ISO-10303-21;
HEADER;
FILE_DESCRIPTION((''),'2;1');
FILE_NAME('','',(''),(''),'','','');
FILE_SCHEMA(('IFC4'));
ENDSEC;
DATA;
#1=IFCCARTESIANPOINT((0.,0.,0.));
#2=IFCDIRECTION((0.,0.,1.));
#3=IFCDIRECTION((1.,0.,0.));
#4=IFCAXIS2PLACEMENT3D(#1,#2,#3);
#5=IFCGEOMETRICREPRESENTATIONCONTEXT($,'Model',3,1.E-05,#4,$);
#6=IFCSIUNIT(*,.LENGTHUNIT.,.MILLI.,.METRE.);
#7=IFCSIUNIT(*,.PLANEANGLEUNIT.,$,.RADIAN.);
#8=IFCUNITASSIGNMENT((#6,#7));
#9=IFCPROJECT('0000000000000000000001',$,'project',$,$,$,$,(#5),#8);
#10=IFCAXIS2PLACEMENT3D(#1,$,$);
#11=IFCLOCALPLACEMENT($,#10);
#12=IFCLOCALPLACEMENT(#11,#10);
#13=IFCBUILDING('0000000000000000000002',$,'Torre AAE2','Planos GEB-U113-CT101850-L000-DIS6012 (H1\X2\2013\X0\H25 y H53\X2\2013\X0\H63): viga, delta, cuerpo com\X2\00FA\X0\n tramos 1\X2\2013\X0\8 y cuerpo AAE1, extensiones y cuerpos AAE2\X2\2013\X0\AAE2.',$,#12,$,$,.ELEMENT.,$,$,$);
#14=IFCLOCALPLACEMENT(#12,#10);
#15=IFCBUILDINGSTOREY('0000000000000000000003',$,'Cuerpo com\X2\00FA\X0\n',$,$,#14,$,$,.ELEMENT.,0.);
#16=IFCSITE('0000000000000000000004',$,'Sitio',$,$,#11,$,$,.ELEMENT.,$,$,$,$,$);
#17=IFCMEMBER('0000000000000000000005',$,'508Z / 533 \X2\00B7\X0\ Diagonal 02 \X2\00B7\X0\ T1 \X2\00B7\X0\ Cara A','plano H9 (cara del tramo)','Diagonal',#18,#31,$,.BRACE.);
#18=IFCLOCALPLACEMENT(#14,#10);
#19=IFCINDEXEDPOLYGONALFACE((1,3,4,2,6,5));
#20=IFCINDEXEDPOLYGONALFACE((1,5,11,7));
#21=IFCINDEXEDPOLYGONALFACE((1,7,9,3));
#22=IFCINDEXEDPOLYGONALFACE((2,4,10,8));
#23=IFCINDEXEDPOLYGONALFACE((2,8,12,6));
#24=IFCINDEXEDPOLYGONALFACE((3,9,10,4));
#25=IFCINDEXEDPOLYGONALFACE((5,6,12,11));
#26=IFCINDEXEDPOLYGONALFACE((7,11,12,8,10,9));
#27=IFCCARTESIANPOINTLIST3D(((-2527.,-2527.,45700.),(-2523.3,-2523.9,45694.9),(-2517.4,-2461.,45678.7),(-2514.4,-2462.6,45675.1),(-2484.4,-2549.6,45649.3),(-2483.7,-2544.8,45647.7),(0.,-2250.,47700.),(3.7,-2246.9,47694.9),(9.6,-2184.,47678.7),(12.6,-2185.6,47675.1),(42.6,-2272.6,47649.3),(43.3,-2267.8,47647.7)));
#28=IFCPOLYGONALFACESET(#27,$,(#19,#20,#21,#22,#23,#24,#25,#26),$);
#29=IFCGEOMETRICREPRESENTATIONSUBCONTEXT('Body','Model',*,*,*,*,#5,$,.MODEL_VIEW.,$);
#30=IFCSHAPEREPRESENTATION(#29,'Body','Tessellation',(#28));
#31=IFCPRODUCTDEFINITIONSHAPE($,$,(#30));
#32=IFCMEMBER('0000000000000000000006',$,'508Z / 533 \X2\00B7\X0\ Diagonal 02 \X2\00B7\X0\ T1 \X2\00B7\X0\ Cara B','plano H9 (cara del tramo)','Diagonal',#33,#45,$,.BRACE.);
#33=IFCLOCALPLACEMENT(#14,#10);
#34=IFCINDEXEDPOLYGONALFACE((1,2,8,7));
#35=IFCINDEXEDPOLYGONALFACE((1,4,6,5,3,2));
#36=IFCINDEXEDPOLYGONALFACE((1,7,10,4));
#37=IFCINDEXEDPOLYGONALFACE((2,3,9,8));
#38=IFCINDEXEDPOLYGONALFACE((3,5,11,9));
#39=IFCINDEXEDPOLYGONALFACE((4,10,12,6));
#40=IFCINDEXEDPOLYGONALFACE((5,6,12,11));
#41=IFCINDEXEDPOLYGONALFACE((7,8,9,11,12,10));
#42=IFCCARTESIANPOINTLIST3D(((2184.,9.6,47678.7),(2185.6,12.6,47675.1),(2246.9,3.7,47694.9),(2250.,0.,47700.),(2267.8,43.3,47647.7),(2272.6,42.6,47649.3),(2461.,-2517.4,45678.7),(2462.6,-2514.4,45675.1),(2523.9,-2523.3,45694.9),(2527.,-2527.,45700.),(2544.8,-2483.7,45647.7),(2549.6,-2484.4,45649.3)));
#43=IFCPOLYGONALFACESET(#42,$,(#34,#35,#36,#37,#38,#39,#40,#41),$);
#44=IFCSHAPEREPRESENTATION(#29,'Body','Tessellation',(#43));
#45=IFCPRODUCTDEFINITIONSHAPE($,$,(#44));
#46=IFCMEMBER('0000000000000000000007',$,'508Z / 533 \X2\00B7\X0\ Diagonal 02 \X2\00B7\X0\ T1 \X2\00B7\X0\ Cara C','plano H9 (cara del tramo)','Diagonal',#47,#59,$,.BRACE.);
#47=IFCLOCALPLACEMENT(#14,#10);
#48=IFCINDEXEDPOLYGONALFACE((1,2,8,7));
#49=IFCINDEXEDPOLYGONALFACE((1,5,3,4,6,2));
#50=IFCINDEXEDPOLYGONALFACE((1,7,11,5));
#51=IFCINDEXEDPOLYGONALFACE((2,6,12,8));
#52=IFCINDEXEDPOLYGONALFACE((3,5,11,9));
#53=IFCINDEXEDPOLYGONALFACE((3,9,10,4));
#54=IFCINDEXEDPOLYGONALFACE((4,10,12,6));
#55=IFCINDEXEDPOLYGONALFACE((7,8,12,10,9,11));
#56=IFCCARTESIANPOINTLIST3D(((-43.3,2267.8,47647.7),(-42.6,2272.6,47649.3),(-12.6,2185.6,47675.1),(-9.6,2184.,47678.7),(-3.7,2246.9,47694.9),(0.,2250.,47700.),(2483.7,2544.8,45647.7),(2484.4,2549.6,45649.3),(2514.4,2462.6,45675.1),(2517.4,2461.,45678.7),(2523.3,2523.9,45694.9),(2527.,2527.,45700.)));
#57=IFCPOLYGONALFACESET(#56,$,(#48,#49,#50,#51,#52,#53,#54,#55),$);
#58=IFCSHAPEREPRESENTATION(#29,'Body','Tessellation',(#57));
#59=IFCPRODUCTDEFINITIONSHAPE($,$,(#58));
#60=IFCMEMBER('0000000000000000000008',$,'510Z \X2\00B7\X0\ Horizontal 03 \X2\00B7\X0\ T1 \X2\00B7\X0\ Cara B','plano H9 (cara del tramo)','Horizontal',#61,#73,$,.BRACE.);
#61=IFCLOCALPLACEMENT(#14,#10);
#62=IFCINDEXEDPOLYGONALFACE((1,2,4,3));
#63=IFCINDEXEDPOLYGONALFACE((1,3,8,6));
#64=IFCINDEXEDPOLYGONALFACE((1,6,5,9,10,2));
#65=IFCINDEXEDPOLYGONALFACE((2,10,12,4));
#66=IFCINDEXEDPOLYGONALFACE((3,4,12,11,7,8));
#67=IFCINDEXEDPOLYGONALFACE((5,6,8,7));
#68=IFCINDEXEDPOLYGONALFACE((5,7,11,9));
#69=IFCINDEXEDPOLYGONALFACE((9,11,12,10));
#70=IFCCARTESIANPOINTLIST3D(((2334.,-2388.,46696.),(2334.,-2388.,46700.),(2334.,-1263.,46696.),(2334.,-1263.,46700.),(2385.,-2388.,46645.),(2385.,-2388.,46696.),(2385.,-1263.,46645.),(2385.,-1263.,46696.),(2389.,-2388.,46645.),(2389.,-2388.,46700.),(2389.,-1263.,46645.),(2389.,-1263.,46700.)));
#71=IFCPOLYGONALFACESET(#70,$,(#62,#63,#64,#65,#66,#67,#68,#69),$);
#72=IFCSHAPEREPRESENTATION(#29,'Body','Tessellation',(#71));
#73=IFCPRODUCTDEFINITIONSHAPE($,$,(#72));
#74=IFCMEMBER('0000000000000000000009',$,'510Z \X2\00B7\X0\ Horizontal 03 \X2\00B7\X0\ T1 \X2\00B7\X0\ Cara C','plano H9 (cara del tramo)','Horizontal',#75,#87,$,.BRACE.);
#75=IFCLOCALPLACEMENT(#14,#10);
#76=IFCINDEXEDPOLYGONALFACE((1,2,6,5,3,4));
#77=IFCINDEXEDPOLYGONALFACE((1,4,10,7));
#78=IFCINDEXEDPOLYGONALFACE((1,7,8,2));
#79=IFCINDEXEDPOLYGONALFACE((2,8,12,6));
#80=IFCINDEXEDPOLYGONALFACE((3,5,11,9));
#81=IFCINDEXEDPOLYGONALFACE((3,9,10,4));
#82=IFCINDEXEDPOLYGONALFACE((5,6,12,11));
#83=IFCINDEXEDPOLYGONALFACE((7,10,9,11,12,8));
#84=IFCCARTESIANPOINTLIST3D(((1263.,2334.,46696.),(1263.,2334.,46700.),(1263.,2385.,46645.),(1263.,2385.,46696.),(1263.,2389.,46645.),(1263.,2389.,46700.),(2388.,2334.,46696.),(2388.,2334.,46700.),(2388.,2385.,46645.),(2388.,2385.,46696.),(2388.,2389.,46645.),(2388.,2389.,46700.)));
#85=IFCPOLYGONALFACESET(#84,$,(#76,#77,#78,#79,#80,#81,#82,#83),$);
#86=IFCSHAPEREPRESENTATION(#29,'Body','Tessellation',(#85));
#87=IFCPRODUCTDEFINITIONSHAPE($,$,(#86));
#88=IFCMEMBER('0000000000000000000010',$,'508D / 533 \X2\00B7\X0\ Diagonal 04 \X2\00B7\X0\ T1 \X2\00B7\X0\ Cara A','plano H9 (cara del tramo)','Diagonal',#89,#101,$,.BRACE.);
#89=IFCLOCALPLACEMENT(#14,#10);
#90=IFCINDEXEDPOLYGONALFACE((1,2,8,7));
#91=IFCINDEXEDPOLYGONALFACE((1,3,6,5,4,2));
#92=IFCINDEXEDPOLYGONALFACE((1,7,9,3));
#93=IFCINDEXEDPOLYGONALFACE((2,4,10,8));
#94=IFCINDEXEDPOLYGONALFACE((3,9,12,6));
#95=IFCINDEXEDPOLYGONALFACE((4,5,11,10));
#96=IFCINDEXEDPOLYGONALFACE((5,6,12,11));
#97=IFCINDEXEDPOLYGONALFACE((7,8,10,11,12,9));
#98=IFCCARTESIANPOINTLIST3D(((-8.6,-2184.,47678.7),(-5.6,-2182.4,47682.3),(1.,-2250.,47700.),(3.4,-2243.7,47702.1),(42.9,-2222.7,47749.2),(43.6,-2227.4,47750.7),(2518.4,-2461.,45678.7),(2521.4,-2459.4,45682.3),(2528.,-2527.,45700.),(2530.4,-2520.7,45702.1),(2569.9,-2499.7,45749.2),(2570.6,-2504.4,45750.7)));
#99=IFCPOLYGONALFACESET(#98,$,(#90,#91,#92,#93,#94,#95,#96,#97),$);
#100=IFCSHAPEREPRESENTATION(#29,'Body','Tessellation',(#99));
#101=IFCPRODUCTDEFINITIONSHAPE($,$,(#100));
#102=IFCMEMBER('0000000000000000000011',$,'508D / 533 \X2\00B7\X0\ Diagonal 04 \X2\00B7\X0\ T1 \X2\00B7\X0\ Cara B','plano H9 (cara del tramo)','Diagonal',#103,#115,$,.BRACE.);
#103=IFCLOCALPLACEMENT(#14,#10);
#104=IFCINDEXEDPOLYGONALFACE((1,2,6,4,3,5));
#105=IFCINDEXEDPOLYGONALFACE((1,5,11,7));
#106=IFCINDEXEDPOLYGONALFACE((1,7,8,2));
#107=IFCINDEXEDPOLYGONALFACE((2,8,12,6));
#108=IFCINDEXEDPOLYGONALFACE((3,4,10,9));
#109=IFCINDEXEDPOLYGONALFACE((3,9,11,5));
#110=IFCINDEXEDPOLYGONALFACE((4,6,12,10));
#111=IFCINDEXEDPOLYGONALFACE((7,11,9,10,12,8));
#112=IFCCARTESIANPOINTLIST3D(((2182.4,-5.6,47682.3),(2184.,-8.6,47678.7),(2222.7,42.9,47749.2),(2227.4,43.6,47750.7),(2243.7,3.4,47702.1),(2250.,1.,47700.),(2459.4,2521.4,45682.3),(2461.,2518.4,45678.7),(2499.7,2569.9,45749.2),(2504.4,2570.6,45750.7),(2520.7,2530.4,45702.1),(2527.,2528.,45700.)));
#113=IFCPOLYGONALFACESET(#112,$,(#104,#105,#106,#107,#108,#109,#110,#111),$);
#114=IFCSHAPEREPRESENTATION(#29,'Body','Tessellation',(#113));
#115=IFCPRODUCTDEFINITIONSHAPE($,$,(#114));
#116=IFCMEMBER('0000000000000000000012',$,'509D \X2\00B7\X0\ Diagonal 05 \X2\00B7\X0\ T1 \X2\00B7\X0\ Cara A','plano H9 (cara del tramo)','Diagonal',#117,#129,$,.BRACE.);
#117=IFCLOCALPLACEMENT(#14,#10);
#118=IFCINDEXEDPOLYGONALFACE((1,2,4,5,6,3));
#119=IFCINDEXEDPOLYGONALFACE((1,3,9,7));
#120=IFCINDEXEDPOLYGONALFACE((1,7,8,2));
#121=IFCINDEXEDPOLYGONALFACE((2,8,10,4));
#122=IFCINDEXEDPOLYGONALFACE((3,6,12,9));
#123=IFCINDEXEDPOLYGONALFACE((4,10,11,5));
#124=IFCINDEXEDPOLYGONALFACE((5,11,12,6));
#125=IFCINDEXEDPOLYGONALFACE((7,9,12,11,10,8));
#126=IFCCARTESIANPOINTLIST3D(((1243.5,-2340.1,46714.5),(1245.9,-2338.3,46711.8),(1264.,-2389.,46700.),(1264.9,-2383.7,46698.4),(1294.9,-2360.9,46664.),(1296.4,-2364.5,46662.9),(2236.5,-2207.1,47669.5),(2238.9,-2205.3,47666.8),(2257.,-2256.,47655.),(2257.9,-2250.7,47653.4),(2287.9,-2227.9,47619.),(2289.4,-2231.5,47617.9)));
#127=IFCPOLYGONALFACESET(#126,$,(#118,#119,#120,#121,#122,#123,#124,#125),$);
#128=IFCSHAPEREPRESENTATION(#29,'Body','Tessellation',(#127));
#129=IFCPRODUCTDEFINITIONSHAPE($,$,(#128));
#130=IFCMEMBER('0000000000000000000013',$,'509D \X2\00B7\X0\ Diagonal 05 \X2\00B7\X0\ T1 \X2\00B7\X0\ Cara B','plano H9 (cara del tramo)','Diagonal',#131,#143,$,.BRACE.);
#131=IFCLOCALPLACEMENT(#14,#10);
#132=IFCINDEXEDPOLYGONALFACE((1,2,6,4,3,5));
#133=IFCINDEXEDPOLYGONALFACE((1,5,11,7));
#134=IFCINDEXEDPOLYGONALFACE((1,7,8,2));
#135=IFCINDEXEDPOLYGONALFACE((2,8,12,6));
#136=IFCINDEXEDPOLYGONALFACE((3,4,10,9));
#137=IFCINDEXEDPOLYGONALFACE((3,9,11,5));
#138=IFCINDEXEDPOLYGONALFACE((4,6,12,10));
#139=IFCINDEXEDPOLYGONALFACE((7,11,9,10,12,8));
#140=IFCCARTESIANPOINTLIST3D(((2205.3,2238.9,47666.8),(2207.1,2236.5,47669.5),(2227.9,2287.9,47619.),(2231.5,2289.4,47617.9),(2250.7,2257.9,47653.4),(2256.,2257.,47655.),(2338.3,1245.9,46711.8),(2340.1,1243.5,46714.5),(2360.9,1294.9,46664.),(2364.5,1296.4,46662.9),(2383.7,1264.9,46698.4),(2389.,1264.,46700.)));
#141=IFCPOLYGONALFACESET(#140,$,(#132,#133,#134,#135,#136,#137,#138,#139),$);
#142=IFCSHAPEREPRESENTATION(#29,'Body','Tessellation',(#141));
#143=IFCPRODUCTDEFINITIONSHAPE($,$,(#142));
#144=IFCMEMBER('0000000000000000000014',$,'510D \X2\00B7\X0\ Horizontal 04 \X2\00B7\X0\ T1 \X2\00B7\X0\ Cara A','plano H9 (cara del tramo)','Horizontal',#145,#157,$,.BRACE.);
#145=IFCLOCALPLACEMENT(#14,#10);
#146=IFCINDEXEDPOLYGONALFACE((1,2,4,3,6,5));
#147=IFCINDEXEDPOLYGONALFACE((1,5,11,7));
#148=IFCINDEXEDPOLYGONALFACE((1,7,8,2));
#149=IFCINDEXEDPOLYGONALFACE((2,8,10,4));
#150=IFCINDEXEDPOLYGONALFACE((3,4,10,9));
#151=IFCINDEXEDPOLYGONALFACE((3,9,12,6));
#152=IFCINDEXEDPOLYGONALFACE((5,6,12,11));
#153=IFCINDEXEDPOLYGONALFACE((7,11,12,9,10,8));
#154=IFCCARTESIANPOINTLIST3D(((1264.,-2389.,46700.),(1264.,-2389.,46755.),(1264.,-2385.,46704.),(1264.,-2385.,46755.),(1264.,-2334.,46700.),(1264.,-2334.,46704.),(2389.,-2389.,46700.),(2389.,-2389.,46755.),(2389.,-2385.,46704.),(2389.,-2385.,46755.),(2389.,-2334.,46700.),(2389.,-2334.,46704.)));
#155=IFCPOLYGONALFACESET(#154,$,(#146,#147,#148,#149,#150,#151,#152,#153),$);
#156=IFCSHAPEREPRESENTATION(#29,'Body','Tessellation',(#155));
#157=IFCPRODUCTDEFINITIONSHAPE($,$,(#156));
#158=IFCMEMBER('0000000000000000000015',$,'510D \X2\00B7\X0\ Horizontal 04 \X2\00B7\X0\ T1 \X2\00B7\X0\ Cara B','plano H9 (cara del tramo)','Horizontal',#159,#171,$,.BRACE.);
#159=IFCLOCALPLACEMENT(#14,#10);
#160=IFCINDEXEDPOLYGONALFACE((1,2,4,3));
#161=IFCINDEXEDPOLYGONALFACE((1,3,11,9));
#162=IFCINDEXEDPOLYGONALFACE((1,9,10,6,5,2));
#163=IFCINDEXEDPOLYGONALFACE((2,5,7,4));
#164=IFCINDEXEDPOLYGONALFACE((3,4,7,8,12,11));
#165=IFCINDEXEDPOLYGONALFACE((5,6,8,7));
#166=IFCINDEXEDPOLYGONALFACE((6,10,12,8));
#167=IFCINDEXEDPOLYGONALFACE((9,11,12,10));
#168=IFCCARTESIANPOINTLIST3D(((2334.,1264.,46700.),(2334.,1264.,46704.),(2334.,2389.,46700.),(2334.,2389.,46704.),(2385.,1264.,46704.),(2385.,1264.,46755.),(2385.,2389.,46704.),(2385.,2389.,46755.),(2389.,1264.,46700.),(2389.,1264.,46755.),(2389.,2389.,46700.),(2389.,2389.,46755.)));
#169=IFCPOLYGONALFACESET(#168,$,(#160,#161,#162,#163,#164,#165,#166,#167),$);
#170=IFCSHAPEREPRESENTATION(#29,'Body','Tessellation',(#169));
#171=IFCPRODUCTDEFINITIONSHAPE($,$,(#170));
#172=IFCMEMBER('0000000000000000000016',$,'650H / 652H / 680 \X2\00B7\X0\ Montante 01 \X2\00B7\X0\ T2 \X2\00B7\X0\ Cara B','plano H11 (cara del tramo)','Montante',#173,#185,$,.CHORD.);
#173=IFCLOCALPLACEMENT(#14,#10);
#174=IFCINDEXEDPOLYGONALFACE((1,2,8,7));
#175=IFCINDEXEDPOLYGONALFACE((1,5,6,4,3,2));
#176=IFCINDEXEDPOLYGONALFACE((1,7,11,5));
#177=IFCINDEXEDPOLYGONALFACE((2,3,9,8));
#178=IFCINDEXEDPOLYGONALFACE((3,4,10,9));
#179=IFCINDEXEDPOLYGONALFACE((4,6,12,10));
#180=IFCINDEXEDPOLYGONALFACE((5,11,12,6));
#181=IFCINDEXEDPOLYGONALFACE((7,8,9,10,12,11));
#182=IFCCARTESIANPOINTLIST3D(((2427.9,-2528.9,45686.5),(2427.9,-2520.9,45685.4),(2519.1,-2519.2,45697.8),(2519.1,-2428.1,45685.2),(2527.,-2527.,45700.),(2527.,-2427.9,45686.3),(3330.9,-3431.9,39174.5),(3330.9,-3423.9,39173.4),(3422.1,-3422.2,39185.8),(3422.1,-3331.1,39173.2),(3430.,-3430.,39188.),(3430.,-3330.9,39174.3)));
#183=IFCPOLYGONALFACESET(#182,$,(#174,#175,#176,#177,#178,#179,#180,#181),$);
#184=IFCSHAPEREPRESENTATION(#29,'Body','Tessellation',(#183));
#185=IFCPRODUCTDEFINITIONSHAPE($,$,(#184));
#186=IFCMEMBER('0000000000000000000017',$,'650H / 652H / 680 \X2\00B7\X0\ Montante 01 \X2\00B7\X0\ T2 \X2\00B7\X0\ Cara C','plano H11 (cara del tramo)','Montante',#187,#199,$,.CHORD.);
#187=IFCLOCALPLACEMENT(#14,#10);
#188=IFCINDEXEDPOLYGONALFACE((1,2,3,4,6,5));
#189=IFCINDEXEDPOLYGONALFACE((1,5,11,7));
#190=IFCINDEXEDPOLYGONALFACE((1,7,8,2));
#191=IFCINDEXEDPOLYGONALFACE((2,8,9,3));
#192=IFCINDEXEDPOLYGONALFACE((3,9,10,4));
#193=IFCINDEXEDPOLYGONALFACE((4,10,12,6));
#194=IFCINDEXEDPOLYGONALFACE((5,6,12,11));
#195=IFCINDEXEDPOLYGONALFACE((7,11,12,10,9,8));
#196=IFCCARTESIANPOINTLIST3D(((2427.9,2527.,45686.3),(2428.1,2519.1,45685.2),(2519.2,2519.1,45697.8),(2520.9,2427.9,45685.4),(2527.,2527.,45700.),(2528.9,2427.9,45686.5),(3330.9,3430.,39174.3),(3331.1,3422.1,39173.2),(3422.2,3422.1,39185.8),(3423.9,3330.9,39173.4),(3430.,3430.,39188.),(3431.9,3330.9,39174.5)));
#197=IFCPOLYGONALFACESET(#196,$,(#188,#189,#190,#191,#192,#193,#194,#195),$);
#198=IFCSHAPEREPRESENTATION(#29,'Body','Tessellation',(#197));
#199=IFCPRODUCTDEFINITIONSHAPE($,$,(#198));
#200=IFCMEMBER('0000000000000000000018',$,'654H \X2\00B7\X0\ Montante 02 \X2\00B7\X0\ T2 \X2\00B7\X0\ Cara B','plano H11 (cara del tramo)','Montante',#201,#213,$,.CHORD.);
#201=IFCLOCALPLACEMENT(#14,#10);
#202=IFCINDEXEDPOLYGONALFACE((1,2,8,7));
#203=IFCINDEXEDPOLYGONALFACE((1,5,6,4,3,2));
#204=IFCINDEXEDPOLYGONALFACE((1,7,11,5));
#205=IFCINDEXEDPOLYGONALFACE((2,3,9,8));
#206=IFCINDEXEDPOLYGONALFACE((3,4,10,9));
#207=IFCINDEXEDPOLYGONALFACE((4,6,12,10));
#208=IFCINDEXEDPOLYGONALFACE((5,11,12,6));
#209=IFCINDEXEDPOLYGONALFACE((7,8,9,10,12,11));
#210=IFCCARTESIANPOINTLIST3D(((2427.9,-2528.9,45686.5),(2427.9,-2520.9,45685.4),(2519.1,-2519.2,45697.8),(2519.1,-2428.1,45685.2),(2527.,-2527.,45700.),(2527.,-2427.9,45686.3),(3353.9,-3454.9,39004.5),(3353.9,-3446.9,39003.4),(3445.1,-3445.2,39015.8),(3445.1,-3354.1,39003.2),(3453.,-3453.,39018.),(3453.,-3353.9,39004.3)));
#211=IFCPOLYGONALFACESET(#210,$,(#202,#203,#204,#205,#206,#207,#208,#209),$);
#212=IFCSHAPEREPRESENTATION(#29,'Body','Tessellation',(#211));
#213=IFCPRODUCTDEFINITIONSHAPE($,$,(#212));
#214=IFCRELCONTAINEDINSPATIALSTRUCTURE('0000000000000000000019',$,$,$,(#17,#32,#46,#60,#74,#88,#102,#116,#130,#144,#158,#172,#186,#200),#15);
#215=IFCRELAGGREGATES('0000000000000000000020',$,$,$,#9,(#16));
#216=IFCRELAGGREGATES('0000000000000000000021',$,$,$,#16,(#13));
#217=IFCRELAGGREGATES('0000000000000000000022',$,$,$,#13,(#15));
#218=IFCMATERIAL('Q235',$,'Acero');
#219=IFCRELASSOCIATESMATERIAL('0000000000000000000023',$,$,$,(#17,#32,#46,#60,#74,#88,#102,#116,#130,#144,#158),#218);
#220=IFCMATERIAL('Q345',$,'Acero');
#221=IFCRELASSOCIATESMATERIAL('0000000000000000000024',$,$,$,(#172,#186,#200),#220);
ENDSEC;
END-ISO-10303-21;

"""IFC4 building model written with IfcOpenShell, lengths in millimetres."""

from ifc_helpers import new_model, si_unit, frame, frame_2d, origin, origin_with_axes, place, context, subcontext, project, spatial, l_section, extrude, material, element, save


model = new_model("IFC4")

# Units and contexts
model_context = context("Model", 3, precision=1e-05, world=origin_with_axes())
body_context = subcontext(model_context, "Body", "Model", "MODEL_VIEW")
ifc_project = project(units=[si_unit("LENGTHUNIT", "METRE", prefix="MILLI"), si_unit("PLANEANGLEUNIT", "RADIAN")], contexts=[model_context])

# Site, building, storey
site_placement = place(None, origin())
site = spatial("IfcSite", under=ifc_project, at=site_placement, Name="Sitio", CompositionType="ELEMENT")
building_placement = place(site_placement, origin())
building = spatial("IfcBuilding", under=site, at=building_placement, Name="Torre AAE2", Description="Planos GEB-U113-CT101850-L000-DIS6012 (H1–H25 y H53–H63): viga, delta, cuerpo común tramos 1–8 y cuerpo AAE1, extensiones y cuerpos AAE2–AAE2.", CompositionType="ELEMENT")
storey_placement = place(building_placement, origin())
storey = spatial("IfcBuildingStorey", under=building, at=storey_placement, Name="Cuerpo común", CompositionType="ELEMENT", Elevation=0.0)

# Members
ifc_material_1 = material(Name="Q235", Category="Acero")
ifc_material_2 = material(Name="Q345", Category="Acero")
for number, where, z_axis, x_axis, name in (
    (1, (0.0, -2250.0, 47700.0), (-0.781247, -0.085637, -0.61832), (0.137116, 0.942809, -0.303825), "508Z / 533 · Diagonal 02 · T1 · Cara A"),
    (2, (2250.0, 0.0, 47700.0), (0.085637, -0.781247, -0.61832), (-0.942809, 0.137116, -0.303825), "508Z / 533 · Diagonal 02 · T1 · Cara B"),
    (3, (0.0, 2250.0, 47700.0), (0.781247, 0.085637, -0.61832), (-0.137116, -0.942809, -0.303825), "508Z / 533 · Diagonal 02 · T1 · Cara C"),
):
    element("IfcMember", number, at=place(storey_placement, frame(where, z_axis=z_axis, x_axis=x_axis)), inside=storey, material=ifc_material_1, Name=name, Description="plano H9 (cara del tramo)", ObjectType="Diagonal", PredefinedType="BRACE", context=body_context, shape_type="SweptSolid", body=[
        extrude(l_section(Depth=70.0, Width=70.0, Thickness=5.0, at=frame_2d((35.0, 35.0))), None, (0.0, 0.0, 1.0), 3234.6),
    ])
for number, where, z_axis, x_axis, name in (
    (4, (2389.0, -1263.0, 46700.0), (0.0, -1.0, 0.0), (-1.0, 0.0, 0.0), "510Z · Horizontal 03 · T1 · Cara B"),
    (5, (1263.0, 2389.0, 46700.0), (1.0, 0.0, 0.0), (0.0, -1.0, 0.0), "510Z · Horizontal 03 · T1 · Cara C"),
):
    element("IfcMember", number, at=place(storey_placement, frame(where, z_axis=z_axis, x_axis=x_axis)), inside=storey, material=ifc_material_1, Name=name, Description="plano H9 (cara del tramo)", ObjectType="Horizontal", PredefinedType="BRACE", context=body_context, shape_type="SweptSolid", body=[
        extrude(l_section(Depth=55.0, Width=55.0, Thickness=4.0, at=frame_2d((27.5, 27.5))), None, (0.0, 0.0, 1.0), 1125.0),
    ])
for number, where, z_axis, x_axis, name in (
    (6, (1.0, -2250.0, 47700.0), (0.781247, -0.085637, -0.61832), (-0.137269, 0.942728, -0.304007), "508D / 533 · Diagonal 04 · T1 · Cara A"),
    (7, (2250.0, 1.0, 47700.0), (0.085637, 0.781247, -0.61832), (-0.942728, -0.137269, -0.304007), "508D / 533 · Diagonal 04 · T1 · Cara B"),
):
    element("IfcMember", number, at=place(storey_placement, frame(where, z_axis=z_axis, x_axis=x_axis)), inside=storey, material=ifc_material_1, Name=name, Description="plano H9 (cara del tramo)", ObjectType="Diagonal", PredefinedType="BRACE", context=body_context, shape_type="SweptSolid", body=[
        extrude(l_section(Depth=70.0, Width=70.0, Thickness=5.0, at=frame_2d((35.0, 35.0))), None, (0.0, 0.0, 1.0), 3234.6),
    ])
for number, where, z_axis, x_axis, name in (
    (8, (2257.0, -2256.0, 47655.0), (-0.717428, -0.096091, -0.689974), (-0.372625, 0.889775, 0.263535), "509D · Diagonal 05 · T1 · Cara A"),
    (9, (2256.0, 2257.0, 47655.0), (0.096091, -0.717428, -0.689974), (-0.889775, -0.372625, 0.263535), "509D · Diagonal 05 · T1 · Cara B"),
):
    element("IfcMember", number, at=place(storey_placement, frame(where, z_axis=z_axis, x_axis=x_axis)), inside=storey, material=ifc_material_1, Name=name, Description="plano H9 (cara del tramo)", ObjectType="Diagonal", PredefinedType="BRACE", context=body_context, shape_type="SweptSolid", body=[
        extrude(l_section(Depth=55.0, Width=55.0, Thickness=4.0, at=frame_2d((27.5, 27.5))), None, (0.0, 0.0, 1.0), 1384.1),
    ])
for number, where, z_axis, x_axis, name in (
    (10, (1264.0, -2389.0, 46700.0), (1.0, 0.0, 0.0), (0.0, 1.0, 0.0), "510D · Horizontal 04 · T1 · Cara A"),
    (11, (2389.0, 1264.0, 46700.0), (0.0, 1.0, 0.0), (-1.0, 0.0, 0.0), "510D · Horizontal 04 · T1 · Cara B"),
):
    element("IfcMember", number, at=place(storey_placement, frame(where, z_axis=z_axis, x_axis=x_axis)), inside=storey, material=ifc_material_1, Name=name, Description="plano H9 (cara del tramo)", ObjectType="Horizontal", PredefinedType="BRACE", context=body_context, shape_type="SweptSolid", body=[
        extrude(l_section(Depth=55.0, Width=55.0, Thickness=4.0, at=frame_2d((27.5, 27.5))), None, (0.0, 0.0, 1.0), 1125.0),
    ])
for number, where, z_axis, x_axis, name in (
    (12, (2527.0, -2527.0, 45700.0), (0.136075, -0.136075, -0.981309), (-0.990699, -0.01869, -0.134786), "650H / 652H / 680 · Montante 01 · T2 · Cara B"),
    (13, (2527.0, 2527.0, 45700.0), (0.136075, 0.136075, -0.981309), (0.01869, -0.990699, -0.134786), "650H / 652H / 680 · Montante 01 · T2 · Cara C"),
):
    element("IfcMember", number, at=place(storey_placement, frame(where, z_axis=z_axis, x_axis=x_axis)), inside=storey, material=ifc_material_2, Name=name, Description="plano H11 (cara del tramo)", ObjectType="Montante", PredefinedType="CHORD", context=body_context, shape_type="SweptSolid", body=[
        extrude(l_section(Depth=100.0, Width=100.0, Thickness=8.0, at=frame_2d((50.0, 50.0))), None, (0.0, 0.0, 1.0), 6636.0),
    ])
for number, where, z_axis, x_axis, name in (
    (14, (2527.0, -2527.0, 45700.0), (0.135994, -0.135994, -0.981331), (-0.99071, -0.018668, -0.134707), "654H · Montante 02 · T2 · Cara B"),
):
    element("IfcMember", number, at=place(storey_placement, frame(where, z_axis=z_axis, x_axis=x_axis)), inside=storey, material=ifc_material_2, Name=name, Description="plano H11 (cara del tramo)", ObjectType="Montante", PredefinedType="CHORD", context=body_context, shape_type="SweptSolid", body=[
        extrude(l_section(Depth=100.0, Width=100.0, Thickness=8.0, at=frame_2d((50.0, 50.0))), None, (0.0, 0.0, 1.0), 6809.1),
    ])

save(model, "model.ifc")
